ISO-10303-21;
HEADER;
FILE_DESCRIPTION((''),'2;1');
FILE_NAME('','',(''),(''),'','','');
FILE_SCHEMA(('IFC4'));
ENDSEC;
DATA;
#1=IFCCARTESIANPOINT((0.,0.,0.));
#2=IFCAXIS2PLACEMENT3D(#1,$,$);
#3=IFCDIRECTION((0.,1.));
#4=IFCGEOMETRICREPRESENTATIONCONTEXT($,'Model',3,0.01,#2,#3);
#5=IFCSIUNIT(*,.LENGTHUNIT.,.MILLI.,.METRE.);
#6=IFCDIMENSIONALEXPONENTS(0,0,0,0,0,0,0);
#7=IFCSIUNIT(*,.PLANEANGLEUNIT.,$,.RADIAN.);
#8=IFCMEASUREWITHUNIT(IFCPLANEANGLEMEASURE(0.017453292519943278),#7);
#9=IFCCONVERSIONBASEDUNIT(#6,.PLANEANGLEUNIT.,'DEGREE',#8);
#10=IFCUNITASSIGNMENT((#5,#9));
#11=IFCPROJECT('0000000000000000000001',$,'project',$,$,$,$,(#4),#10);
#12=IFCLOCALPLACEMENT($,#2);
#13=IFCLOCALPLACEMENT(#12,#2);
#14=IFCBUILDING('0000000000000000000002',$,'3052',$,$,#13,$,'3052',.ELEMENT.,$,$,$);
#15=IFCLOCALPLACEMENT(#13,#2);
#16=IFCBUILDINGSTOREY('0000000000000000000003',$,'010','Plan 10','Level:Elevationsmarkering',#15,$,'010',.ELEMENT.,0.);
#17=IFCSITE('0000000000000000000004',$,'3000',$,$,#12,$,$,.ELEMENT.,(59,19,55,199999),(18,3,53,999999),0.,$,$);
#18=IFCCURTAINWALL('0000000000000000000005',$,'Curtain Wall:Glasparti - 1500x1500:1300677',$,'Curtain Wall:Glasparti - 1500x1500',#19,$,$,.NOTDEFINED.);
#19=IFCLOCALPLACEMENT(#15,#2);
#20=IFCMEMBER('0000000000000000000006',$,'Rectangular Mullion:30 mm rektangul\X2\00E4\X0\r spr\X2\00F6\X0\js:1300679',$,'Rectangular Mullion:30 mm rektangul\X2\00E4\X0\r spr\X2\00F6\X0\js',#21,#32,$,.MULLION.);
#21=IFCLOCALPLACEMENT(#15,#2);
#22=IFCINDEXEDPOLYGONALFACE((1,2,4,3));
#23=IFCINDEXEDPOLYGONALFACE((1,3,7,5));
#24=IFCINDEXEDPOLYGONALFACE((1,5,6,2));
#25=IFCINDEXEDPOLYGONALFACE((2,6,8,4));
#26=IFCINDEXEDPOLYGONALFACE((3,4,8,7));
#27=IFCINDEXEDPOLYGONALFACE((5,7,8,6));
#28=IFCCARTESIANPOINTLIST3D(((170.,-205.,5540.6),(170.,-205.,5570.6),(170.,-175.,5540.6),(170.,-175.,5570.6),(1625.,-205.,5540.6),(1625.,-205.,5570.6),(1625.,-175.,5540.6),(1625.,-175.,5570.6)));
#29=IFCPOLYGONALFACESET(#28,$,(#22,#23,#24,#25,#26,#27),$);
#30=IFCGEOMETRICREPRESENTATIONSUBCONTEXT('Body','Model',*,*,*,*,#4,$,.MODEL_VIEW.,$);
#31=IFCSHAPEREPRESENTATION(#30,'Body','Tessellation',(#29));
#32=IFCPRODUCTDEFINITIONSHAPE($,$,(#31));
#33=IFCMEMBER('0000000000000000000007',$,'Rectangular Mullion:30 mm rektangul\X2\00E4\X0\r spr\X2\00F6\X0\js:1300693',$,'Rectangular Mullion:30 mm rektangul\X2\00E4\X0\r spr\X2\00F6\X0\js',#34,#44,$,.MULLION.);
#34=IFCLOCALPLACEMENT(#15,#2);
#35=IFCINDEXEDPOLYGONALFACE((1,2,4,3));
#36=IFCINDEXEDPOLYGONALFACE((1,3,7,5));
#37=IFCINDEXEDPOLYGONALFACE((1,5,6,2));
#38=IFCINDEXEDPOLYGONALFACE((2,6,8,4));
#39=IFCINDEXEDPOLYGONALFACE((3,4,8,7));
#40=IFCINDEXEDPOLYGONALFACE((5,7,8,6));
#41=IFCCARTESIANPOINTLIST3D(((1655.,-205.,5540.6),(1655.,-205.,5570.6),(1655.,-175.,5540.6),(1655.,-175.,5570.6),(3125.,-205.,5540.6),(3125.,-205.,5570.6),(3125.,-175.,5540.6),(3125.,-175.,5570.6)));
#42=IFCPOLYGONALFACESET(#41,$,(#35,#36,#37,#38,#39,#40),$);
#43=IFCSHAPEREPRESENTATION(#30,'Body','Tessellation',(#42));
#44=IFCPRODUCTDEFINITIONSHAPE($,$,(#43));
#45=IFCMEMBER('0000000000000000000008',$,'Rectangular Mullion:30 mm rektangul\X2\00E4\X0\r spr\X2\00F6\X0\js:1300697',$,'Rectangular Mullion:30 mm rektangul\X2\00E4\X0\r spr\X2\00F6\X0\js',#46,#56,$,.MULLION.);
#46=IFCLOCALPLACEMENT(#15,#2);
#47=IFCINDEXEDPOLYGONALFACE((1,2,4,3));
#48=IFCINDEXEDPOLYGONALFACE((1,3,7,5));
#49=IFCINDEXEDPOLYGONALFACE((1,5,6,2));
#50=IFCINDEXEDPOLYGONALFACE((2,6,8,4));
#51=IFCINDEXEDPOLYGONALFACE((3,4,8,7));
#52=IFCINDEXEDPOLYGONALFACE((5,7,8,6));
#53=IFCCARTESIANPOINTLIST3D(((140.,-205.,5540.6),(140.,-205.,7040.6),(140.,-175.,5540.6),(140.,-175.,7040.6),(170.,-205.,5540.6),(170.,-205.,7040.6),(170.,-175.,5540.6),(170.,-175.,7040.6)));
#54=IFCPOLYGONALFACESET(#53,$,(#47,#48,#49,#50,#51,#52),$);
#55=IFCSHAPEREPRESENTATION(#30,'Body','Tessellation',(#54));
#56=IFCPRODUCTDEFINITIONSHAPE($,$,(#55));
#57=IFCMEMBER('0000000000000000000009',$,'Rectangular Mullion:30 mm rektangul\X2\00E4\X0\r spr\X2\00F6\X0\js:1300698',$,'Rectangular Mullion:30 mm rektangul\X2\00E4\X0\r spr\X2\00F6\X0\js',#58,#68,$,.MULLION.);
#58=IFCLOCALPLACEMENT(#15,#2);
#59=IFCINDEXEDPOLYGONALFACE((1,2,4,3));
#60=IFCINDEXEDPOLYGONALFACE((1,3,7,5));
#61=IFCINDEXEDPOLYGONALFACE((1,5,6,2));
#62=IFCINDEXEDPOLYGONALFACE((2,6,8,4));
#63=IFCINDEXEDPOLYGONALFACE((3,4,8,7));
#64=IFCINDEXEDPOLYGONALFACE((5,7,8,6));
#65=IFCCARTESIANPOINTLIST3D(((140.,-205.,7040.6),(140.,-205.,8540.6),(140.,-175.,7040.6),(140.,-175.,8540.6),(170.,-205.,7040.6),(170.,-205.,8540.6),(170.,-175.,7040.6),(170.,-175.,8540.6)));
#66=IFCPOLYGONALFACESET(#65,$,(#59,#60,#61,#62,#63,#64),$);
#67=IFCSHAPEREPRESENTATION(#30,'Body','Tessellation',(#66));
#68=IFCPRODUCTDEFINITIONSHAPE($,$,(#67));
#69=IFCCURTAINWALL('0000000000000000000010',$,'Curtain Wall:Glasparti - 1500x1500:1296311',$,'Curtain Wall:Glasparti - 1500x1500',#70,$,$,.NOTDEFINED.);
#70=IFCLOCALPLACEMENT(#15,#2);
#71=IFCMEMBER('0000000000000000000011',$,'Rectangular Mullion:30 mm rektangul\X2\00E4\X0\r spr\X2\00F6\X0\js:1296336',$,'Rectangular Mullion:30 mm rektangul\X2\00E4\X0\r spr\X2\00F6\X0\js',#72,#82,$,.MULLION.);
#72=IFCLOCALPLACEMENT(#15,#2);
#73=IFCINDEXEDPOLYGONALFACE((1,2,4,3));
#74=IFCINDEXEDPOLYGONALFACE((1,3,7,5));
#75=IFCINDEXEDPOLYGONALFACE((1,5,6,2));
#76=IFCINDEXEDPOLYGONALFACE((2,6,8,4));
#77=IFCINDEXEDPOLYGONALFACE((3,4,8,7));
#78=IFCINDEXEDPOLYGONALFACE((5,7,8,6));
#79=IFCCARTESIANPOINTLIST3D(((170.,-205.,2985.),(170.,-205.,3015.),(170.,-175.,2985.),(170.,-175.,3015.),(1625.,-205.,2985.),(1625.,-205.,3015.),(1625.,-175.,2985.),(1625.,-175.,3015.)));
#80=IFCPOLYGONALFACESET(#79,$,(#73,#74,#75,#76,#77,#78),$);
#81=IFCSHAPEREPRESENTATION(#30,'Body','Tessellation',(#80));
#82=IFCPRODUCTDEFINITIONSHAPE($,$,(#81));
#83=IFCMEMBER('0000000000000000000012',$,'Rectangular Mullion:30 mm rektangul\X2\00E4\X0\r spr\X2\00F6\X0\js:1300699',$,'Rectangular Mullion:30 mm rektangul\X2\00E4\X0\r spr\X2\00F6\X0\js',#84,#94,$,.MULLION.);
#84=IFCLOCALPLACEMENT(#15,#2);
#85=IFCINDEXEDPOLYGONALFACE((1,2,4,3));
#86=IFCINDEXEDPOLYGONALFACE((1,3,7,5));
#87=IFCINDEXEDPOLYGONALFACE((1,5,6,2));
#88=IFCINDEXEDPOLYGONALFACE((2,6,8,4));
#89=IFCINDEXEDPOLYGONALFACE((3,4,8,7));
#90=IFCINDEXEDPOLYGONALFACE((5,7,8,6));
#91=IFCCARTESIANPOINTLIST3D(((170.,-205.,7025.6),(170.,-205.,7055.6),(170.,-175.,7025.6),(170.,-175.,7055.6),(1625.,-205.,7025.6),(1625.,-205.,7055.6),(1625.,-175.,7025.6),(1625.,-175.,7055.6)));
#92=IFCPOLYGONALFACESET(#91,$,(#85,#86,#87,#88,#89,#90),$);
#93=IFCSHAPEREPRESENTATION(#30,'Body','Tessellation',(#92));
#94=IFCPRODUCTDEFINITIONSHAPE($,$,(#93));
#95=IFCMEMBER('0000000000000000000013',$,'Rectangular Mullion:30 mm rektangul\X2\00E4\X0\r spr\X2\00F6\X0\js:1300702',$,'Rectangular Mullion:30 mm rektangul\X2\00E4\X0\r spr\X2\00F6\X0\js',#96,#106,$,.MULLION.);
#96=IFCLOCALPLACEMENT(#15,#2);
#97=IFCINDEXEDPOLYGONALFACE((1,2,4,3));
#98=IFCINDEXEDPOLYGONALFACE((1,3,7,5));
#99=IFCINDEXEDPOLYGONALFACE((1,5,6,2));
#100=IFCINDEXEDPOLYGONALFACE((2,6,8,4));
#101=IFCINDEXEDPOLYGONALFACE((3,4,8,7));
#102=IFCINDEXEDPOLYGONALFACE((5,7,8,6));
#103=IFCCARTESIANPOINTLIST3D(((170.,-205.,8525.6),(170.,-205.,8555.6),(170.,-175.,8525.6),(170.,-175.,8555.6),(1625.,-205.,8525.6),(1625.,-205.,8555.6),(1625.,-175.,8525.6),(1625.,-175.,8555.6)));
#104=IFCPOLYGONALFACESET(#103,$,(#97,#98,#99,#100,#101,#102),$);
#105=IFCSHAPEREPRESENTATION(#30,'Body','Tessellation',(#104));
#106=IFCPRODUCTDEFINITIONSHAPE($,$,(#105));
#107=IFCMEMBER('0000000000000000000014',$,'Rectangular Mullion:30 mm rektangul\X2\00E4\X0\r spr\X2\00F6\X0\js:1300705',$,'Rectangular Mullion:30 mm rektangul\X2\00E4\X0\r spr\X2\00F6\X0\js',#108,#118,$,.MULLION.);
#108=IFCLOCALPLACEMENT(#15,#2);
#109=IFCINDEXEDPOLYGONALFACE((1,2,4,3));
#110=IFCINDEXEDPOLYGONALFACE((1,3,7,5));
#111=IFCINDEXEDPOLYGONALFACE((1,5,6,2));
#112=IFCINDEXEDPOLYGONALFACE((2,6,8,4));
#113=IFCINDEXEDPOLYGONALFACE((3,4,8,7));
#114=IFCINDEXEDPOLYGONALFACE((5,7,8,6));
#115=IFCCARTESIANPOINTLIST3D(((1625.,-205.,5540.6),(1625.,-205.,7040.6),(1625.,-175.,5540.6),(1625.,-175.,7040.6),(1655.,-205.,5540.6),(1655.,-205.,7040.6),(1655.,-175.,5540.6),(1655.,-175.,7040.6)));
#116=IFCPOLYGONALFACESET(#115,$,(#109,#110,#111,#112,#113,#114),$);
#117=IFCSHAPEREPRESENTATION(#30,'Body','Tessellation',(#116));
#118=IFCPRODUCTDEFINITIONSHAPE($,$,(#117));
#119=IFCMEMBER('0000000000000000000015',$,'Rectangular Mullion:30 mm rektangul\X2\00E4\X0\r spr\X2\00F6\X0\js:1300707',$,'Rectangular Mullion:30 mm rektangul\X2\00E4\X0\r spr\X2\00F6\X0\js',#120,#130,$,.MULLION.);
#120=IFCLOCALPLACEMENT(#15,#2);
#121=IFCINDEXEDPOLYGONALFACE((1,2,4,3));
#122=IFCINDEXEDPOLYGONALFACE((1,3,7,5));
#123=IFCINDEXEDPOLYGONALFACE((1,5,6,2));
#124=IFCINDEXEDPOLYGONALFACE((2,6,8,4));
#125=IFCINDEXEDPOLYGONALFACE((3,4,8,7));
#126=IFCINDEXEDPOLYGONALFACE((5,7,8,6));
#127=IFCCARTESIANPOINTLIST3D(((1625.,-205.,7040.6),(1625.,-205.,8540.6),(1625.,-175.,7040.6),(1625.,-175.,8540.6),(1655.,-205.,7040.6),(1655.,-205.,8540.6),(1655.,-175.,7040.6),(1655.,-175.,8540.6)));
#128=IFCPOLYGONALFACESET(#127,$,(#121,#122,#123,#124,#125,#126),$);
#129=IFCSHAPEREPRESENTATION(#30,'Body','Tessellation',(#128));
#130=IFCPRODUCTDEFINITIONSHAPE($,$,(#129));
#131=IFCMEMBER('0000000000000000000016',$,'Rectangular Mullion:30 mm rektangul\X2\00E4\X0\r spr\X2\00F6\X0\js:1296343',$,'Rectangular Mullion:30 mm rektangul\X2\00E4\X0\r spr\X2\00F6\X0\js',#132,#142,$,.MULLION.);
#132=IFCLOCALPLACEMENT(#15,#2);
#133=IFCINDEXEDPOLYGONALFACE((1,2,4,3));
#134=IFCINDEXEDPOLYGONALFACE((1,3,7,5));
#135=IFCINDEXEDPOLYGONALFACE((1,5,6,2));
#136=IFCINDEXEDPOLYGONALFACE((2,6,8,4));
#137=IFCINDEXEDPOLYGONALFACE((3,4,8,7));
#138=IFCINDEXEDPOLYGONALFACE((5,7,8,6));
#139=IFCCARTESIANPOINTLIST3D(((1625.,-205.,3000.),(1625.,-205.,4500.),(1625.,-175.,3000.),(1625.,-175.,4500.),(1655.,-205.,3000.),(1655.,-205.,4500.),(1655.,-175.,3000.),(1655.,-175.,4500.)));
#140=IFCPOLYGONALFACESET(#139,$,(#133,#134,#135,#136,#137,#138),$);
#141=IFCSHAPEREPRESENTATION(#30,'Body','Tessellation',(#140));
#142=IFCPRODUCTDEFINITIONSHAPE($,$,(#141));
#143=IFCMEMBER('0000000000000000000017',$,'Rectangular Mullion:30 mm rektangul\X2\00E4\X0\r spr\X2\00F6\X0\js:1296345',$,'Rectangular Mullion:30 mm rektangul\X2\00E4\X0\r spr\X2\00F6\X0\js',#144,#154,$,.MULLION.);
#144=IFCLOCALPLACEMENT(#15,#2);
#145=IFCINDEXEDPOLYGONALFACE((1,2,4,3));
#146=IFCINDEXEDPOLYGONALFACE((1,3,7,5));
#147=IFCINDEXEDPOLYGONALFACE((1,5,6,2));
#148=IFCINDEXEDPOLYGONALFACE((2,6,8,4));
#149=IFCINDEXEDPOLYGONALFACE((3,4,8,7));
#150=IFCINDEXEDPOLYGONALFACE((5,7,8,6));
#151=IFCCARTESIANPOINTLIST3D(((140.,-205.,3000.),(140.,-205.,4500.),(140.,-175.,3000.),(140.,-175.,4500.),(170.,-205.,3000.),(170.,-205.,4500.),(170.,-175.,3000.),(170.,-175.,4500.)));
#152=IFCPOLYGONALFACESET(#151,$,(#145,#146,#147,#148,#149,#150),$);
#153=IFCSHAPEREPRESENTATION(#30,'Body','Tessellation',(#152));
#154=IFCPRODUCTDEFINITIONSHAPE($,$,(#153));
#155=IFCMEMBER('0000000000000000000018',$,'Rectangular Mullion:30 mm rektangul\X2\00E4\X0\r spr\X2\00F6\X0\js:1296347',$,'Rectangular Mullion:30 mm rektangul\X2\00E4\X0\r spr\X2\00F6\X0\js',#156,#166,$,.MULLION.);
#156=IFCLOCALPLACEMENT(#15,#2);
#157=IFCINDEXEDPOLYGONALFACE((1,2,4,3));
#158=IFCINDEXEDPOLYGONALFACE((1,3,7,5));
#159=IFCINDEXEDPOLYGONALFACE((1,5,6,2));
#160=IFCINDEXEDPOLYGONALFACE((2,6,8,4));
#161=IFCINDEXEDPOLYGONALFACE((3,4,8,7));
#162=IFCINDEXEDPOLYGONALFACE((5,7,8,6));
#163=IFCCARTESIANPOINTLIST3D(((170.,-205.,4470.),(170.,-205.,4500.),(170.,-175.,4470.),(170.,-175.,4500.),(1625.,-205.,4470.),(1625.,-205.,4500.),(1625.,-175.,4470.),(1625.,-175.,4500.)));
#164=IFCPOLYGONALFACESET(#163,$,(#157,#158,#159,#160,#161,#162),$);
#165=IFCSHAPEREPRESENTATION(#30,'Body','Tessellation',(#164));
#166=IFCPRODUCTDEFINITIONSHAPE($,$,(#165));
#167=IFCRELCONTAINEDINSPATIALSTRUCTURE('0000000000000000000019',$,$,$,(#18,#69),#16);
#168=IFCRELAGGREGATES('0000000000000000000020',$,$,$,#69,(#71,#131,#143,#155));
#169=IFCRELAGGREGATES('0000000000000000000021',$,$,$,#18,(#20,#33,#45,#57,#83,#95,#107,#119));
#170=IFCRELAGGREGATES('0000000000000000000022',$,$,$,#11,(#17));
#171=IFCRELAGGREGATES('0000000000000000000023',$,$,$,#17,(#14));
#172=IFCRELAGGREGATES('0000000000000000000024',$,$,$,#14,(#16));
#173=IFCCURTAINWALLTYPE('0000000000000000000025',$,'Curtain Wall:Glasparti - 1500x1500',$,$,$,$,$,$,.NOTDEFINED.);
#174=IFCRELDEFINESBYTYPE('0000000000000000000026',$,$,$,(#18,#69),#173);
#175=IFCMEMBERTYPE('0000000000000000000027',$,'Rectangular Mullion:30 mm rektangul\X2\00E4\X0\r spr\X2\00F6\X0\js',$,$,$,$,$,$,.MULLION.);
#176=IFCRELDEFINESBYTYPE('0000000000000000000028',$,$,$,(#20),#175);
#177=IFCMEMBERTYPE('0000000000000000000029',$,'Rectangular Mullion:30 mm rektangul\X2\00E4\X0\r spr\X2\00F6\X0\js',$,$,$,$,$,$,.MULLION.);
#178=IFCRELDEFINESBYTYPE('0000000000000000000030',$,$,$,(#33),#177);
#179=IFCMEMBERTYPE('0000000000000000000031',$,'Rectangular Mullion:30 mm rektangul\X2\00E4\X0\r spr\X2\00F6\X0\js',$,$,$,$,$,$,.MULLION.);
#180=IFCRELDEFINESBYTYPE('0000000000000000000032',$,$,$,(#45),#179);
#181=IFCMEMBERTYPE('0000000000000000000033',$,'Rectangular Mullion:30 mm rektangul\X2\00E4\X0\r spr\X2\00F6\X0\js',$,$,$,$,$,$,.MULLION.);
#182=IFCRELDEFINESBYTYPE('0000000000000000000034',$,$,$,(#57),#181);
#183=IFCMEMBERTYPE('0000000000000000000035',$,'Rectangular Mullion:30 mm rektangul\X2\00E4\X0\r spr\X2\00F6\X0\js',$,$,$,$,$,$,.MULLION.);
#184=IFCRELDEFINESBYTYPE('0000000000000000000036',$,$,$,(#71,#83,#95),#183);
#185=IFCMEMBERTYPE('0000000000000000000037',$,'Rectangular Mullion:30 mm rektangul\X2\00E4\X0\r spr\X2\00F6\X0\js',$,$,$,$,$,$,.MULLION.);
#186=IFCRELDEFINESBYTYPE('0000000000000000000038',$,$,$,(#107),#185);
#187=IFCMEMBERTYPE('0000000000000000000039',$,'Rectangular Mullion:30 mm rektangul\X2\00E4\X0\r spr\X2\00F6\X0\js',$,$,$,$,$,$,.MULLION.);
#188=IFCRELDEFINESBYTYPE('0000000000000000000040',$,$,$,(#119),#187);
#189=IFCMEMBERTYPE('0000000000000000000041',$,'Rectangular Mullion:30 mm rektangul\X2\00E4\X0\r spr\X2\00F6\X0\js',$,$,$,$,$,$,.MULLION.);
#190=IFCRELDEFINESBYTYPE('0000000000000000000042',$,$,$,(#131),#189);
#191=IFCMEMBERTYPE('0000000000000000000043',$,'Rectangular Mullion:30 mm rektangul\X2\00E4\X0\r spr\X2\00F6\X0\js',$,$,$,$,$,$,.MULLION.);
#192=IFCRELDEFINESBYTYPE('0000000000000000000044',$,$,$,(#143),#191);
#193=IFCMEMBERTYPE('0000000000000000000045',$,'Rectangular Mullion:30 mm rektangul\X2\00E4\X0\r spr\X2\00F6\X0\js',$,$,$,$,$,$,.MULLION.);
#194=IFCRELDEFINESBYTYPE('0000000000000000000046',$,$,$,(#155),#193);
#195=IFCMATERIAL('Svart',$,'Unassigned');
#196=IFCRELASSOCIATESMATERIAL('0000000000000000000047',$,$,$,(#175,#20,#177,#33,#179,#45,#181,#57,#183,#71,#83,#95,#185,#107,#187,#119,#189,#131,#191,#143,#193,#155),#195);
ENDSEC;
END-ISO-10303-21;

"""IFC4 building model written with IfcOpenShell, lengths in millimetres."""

from ifc_helpers import new_model, entity, si_unit, converted_unit, direction, frame, origin, place, context, subcontext, project, spatial, indexed_curve, outline, extrude, source, transform, mapped, material, type_object, type_shapes, element, aggregate, save


model = new_model("IFC4")

# Units and contexts
model_context = context("Model", 3, precision=0.01, world=origin(), true_north=direction((0.0, 1.0)))
body_context = subcontext(model_context, "Body", "Model", "MODEL_VIEW")
ifc_project = project(units=[si_unit("LENGTHUNIT", "METRE", prefix="MILLI"), converted_unit("PLANEANGLEUNIT", "DEGREE", entity("IfcPlaneAngleMeasure", 0.017453292519943278), si_unit("PLANEANGLEUNIT", "RADIAN"), dimensions=[0, 0, 0, 0, 0, 0, 0])], contexts=[model_context])

# Site, building, storey
site_placement = place(None, origin())
site = spatial("IfcSite", under=ifc_project, at=site_placement, Name="3000", CompositionType="ELEMENT", RefLatitude=(59, 19, 55, 199999), RefLongitude=(18, 3, 53, 999999), RefElevation=0.0)
building_placement = place(site_placement, origin())
building = spatial("IfcBuilding", under=site, at=building_placement, Name="3052", LongName="3052", CompositionType="ELEMENT")
storey_placement = place(building_placement, origin())
storey = spatial("IfcBuildingStorey", under=building, at=storey_placement, Name="010", Description="Plan 10", ObjectType="Level:Elevationsmarkering", LongName="010", CompositionType="ELEMENT", Elevation=0.0)

# Curtain wall, members
curtain_wall_type = type_object("IfcCurtainWallType", Name="Curtain Wall:Glasparti - 1500x1500", PredefinedType="NOTDEFINED")
curtain_wall_1_placement = place(storey_placement, origin())
curtain_wall_1 = element("IfcCurtainWall", 1, at=curtain_wall_1_placement, inside=storey, type_object=curtain_wall_type, Name="Curtain Wall:Glasparti - 1500x1500:1300677", ObjectType="Curtain Wall:Glasparti - 1500x1500", PredefinedType="NOTDEFINED")
ifc_material_1 = material(Name="Svart", Category="Unassigned")
member_type_1 = type_object("IfcMemberType", Name="Rectangular Mullion:30 mm rektangulär spröjs", PredefinedType="MULLION", material=ifc_material_1)
shared_shape_1 = source(origin(), body_context, "Body", "SweptSolid", [
    extrude(outline(indexed_curve([(-15.0, -15.0), (15.0, -15.0), (15.0, 15.0), (-15.0, 15.0), (-15.0, -15.0)], self_intersect=False)), frame((-15.0, 0.0, -1455.0), z_axis=(0.0, 0.0, 1.0), x_axis=(-1.0, 0.0, 0.0)), (0.0, 0.0, 1.0), 1455.0),
])
type_shapes(member_type_1, [shared_shape_1])
member_1_placement = place(curtain_wall_1_placement, frame((170.0, -190.0, 5540.6), z_axis=(-1.0, 0.0, 0.0), x_axis=(0.0, 0.0, -1.0)))
member_1 = element("IfcMember", 2, at=member_1_placement, type_object=member_type_1, material=ifc_material_1, Name="Rectangular Mullion:30 mm rektangulär spröjs:1300679", ObjectType="Rectangular Mullion:30 mm rektangulär spröjs", PredefinedType="MULLION", context=body_context, shape_type="MappedRepresentation", body=[
    mapped(shared_shape_1, transform((0.0, 0.0, 0.0), scale=1.0)),
])
member_type_2 = type_object("IfcMemberType", Name="Rectangular Mullion:30 mm rektangulär spröjs", PredefinedType="MULLION", material=ifc_material_1)
shared_shape_2 = source(origin(), body_context, "Body", "SweptSolid", [
    extrude(outline(indexed_curve([(-15.0, -15.0), (15.0, -15.0), (15.0, 15.0), (-15.0, 15.0), (-15.0, -15.0)], self_intersect=False)), frame((-15.0, 0.0, -1470.0), z_axis=(0.0, 0.0, 1.0), x_axis=(-1.0, 0.0, 0.0)), (0.0, 0.0, 1.0), 1470.0),
])
type_shapes(member_type_2, [shared_shape_2])
member_2_placement = place(curtain_wall_1_placement, frame((1655.0, -190.0, 5540.6), z_axis=(-1.0, 0.0, 0.0), x_axis=(0.0, 0.0, -1.0)))
member_2 = element("IfcMember", 3, at=member_2_placement, type_object=member_type_2, material=ifc_material_1, Name="Rectangular Mullion:30 mm rektangulär spröjs:1300693", ObjectType="Rectangular Mullion:30 mm rektangulär spröjs", PredefinedType="MULLION", context=body_context, shape_type="MappedRepresentation", body=[
    mapped(shared_shape_2, transform((0.0, 0.0, 0.0), scale=1.0)),
])
member_type_3 = type_object("IfcMemberType", Name="Rectangular Mullion:30 mm rektangulär spröjs", PredefinedType="MULLION", material=ifc_material_1)
shared_shape_3 = source(origin(), body_context, "Body", "SweptSolid", [
    extrude(outline(indexed_curve([(-15.0, -15.0), (15.0, -15.0), (15.0, 15.0), (-15.0, 15.0), (-15.0, -15.0)], self_intersect=False)), frame((-15.0, 0.0, -1500.0), z_axis=(0.0, 0.0, 1.0), x_axis=(-1.0, 0.0, 0.0)), (0.0, 0.0, 1.0), 1500.0),
])
type_shapes(member_type_3, [shared_shape_3])
member_3_placement = place(curtain_wall_1_placement, frame((140.0, -190.0, 7040.6), z_axis=(0.0, 0.0, 1.0), x_axis=(-1.0, 0.0, 0.0)))
member_3 = element("IfcMember", 4, at=member_3_placement, type_object=member_type_3, material=ifc_material_1, Name="Rectangular Mullion:30 mm rektangulär spröjs:1300697", ObjectType="Rectangular Mullion:30 mm rektangulär spröjs", PredefinedType="MULLION", context=body_context, shape_type="MappedRepresentation", body=[
    mapped(shared_shape_3, transform((0.0, 0.0, 0.0), scale=1.0)),
])
member_type_4 = type_object("IfcMemberType", Name="Rectangular Mullion:30 mm rektangulär spröjs", PredefinedType="MULLION", material=ifc_material_1)
shared_shape_4 = source(origin(), body_context, "Body", "SweptSolid", [
    extrude(outline(indexed_curve([(-15.0, -15.0), (15.0, -15.0), (15.0, 15.0), (-15.0, 15.0), (-15.0, -15.0)], self_intersect=False)), frame((-15.0, 0.0, -1500.0), z_axis=(0.0, 0.0, 1.0), x_axis=(-1.0, 0.0, 0.0)), (0.0, 0.0, 1.0), 1500.0),
])
type_shapes(member_type_4, [shared_shape_4])
member_4_placement = place(curtain_wall_1_placement, frame((140.0, -190.0, 8540.6), z_axis=(0.0, 0.0, 1.0), x_axis=(-1.0, 0.0, 0.0)))
member_4 = element("IfcMember", 5, at=member_4_placement, type_object=member_type_4, material=ifc_material_1, Name="Rectangular Mullion:30 mm rektangulär spröjs:1300698", ObjectType="Rectangular Mullion:30 mm rektangulär spröjs", PredefinedType="MULLION", context=body_context, shape_type="MappedRepresentation", body=[
    mapped(shared_shape_4, transform((0.0, 0.0, 0.0), scale=1.0)),
])

# Curtain wall, member
curtain_wall_2_placement = place(storey_placement, origin())
curtain_wall_2 = element("IfcCurtainWall", 6, at=curtain_wall_2_placement, inside=storey, type_object=curtain_wall_type, Name="Curtain Wall:Glasparti - 1500x1500:1296311", ObjectType="Curtain Wall:Glasparti - 1500x1500", PredefinedType="NOTDEFINED")
member_type_5 = type_object("IfcMemberType", Name="Rectangular Mullion:30 mm rektangulär spröjs", PredefinedType="MULLION", material=ifc_material_1)
shared_shape_5 = source(origin(), body_context, "Body", "SweptSolid", [
    extrude(outline(indexed_curve([(-15.0, -15.0), (15.0, -15.0), (15.0, 15.0), (-15.0, 15.0), (-15.0, -15.0)], self_intersect=False)), frame((0.0, 0.0, -1455.0), z_axis=(0.0, 0.0, 1.0), x_axis=(-1.0, 0.0, 0.0)), (0.0, 0.0, 1.0), 1455.0),
])
type_shapes(member_type_5, [shared_shape_5])
member_5_placement = place(curtain_wall_2_placement, frame((1625.0, -190.0, 3000.0), z_axis=(1.0, 0.0, 0.0), x_axis=(0.0, 0.0, 1.0)))
member_5 = element("IfcMember", 7, at=member_5_placement, type_object=member_type_5, material=ifc_material_1, Name="Rectangular Mullion:30 mm rektangulär spröjs:1296336", ObjectType="Rectangular Mullion:30 mm rektangulär spröjs", PredefinedType="MULLION", context=body_context, shape_type="MappedRepresentation", body=[
    mapped(shared_shape_5, transform((0.0, 0.0, 0.0), scale=1.0)),
])

# Members
member_6_placement = place(curtain_wall_1_placement, frame((1625.0, -190.0, 7040.6), z_axis=(1.0, 0.0, 0.0), x_axis=(0.0, 0.0, 1.0)))
member_6 = element("IfcMember", 8, at=member_6_placement, type_object=member_type_5, material=ifc_material_1, Name="Rectangular Mullion:30 mm rektangulär spröjs:1300699", ObjectType="Rectangular Mullion:30 mm rektangulär spröjs", PredefinedType="MULLION", context=body_context, shape_type="MappedRepresentation", body=[
    mapped(shared_shape_5, transform((0.0, 0.0, 0.0), scale=1.0)),
])
member_7_placement = place(curtain_wall_1_placement, frame((1625.0, -190.0, 8540.6), z_axis=(1.0, 0.0, 0.0), x_axis=(0.0, 0.0, 1.0)))
member_7 = element("IfcMember", 9, at=member_7_placement, type_object=member_type_5, material=ifc_material_1, Name="Rectangular Mullion:30 mm rektangulär spröjs:1300702", ObjectType="Rectangular Mullion:30 mm rektangulär spröjs", PredefinedType="MULLION", context=body_context, shape_type="MappedRepresentation", body=[
    mapped(shared_shape_5, transform((0.0, 0.0, 0.0), scale=1.0)),
])
member_type_6 = type_object("IfcMemberType", Name="Rectangular Mullion:30 mm rektangulär spröjs", PredefinedType="MULLION", material=ifc_material_1)
shared_shape_6 = source(origin(), body_context, "Body", "SweptSolid", [
    extrude(outline(indexed_curve([(-15.0, -15.0), (15.0, -15.0), (15.0, 15.0), (-15.0, 15.0), (-15.0, -15.0)], self_intersect=False)), frame((0.0, 0.0, -1500.0), z_axis=(0.0, 0.0, 1.0), x_axis=(-1.0, 0.0, 0.0)), (0.0, 0.0, 1.0), 1500.0),
])
type_shapes(member_type_6, [shared_shape_6])
member_8_placement = place(curtain_wall_1_placement, frame((1640.0, -190.0, 5540.6), z_axis=(0.0, 0.0, -1.0), x_axis=(1.0, 0.0, 0.0)))
member_8 = element("IfcMember", 10, at=member_8_placement, type_object=member_type_6, material=ifc_material_1, Name="Rectangular Mullion:30 mm rektangulär spröjs:1300705", ObjectType="Rectangular Mullion:30 mm rektangulär spröjs", PredefinedType="MULLION", context=body_context, shape_type="MappedRepresentation", body=[
    mapped(shared_shape_6, transform((0.0, 0.0, 0.0), scale=1.0)),
])
member_type_7 = type_object("IfcMemberType", Name="Rectangular Mullion:30 mm rektangulär spröjs", PredefinedType="MULLION", material=ifc_material_1)
shared_shape_7 = source(origin(), body_context, "Body", "SweptSolid", [
    extrude(outline(indexed_curve([(-15.0, -15.0), (15.0, -15.0), (15.0, 15.0), (-15.0, 15.0), (-15.0, -15.0)], self_intersect=False)), frame((0.0, 0.0, -1500.0), z_axis=(0.0, 0.0, 1.0), x_axis=(-1.0, 0.0, 0.0)), (0.0, 0.0, 1.0), 1500.0),
])
type_shapes(member_type_7, [shared_shape_7])
member_9_placement = place(curtain_wall_1_placement, frame((1640.0, -190.0, 7040.6), z_axis=(0.0, 0.0, -1.0), x_axis=(1.0, 0.0, 0.0)))
member_9 = element("IfcMember", 11, at=member_9_placement, type_object=member_type_7, material=ifc_material_1, Name="Rectangular Mullion:30 mm rektangulär spröjs:1300707", ObjectType="Rectangular Mullion:30 mm rektangulär spröjs", PredefinedType="MULLION", context=body_context, shape_type="MappedRepresentation", body=[
    mapped(shared_shape_7, transform((0.0, 0.0, 0.0), scale=1.0)),
])
member_type_8 = type_object("IfcMemberType", Name="Rectangular Mullion:30 mm rektangulär spröjs", PredefinedType="MULLION", material=ifc_material_1)
shared_shape_8 = source(origin(), body_context, "Body", "SweptSolid", [
    extrude(outline(indexed_curve([(-15.0, -15.0), (15.0, -15.0), (15.0, 15.0), (-15.0, 15.0), (-15.0, -15.0)], self_intersect=False)), frame((0.0, 0.0, -1500.0), z_axis=(0.0, 0.0, 1.0), x_axis=(-1.0, 0.0, 0.0)), (0.0, 0.0, 1.0), 1500.0),
])
type_shapes(member_type_8, [shared_shape_8])
member_10_placement = place(curtain_wall_2_placement, frame((1640.0, -190.0, 3000.0), z_axis=(0.0, 0.0, -1.0), x_axis=(1.0, 0.0, 0.0)))
member_10 = element("IfcMember", 12, at=member_10_placement, type_object=member_type_8, material=ifc_material_1, Name="Rectangular Mullion:30 mm rektangulär spröjs:1296343", ObjectType="Rectangular Mullion:30 mm rektangulär spröjs", PredefinedType="MULLION", context=body_context, shape_type="MappedRepresentation", body=[
    mapped(shared_shape_8, transform((0.0, 0.0, 0.0), scale=1.0)),
])
member_type_9 = type_object("IfcMemberType", Name="Rectangular Mullion:30 mm rektangulär spröjs", PredefinedType="MULLION", material=ifc_material_1)
shared_shape_9 = source(origin(), body_context, "Body", "SweptSolid", [
    extrude(outline(indexed_curve([(-15.0, -15.0), (15.0, -15.0), (15.0, 15.0), (-15.0, 15.0), (-15.0, -15.0)], self_intersect=False)), frame((-15.0, 0.0, -1500.0), z_axis=(0.0, 0.0, 1.0), x_axis=(-1.0, 0.0, 0.0)), (0.0, 0.0, 1.0), 1500.0),
])
type_shapes(member_type_9, [shared_shape_9])
member_11_placement = place(curtain_wall_2_placement, frame((140.0, -190.0, 4500.0), z_axis=(0.0, 0.0, 1.0), x_axis=(-1.0, 0.0, 0.0)))
member_11 = element("IfcMember", 13, at=member_11_placement, type_object=member_type_9, material=ifc_material_1, Name="Rectangular Mullion:30 mm rektangulär spröjs:1296345", ObjectType="Rectangular Mullion:30 mm rektangulär spröjs", PredefinedType="MULLION", context=body_context, shape_type="MappedRepresentation", body=[
    mapped(shared_shape_9, transform((0.0, 0.0, 0.0), scale=1.0)),
])
member_type_10 = type_object("IfcMemberType", Name="Rectangular Mullion:30 mm rektangulär spröjs", PredefinedType="MULLION", material=ifc_material_1)
shared_shape_10 = source(origin(), body_context, "Body", "SweptSolid", [
    extrude(outline(indexed_curve([(-15.0, -15.0), (15.0, -15.0), (15.0, 15.0), (-15.0, 15.0), (-15.0, -15.0)], self_intersect=False)), frame((-15.0, 0.0, -1455.0), z_axis=(0.0, 0.0, 1.0), x_axis=(-1.0, 0.0, 0.0)), (0.0, 0.0, 1.0), 1455.0),
])
type_shapes(member_type_10, [shared_shape_10])
member_12_placement = place(curtain_wall_2_placement, frame((1625.0, -190.0, 4500.0), z_axis=(1.0, 0.0, 0.0), x_axis=(0.0, 0.0, 1.0)))
member_12 = element("IfcMember", 14, at=member_12_placement, type_object=member_type_10, material=ifc_material_1, Name="Rectangular Mullion:30 mm rektangulär spröjs:1296347", ObjectType="Rectangular Mullion:30 mm rektangulär spröjs", PredefinedType="MULLION", context=body_context, shape_type="MappedRepresentation", body=[
    mapped(shared_shape_10, transform((0.0, 0.0, 0.0), scale=1.0)),
])

aggregate(curtain_wall_2, [member_5, member_10, member_11, member_12])
aggregate(curtain_wall_1, [member_1, member_2, member_3, member_4, member_6, member_7, member_8, member_9])

save(model, "model.ifc")
